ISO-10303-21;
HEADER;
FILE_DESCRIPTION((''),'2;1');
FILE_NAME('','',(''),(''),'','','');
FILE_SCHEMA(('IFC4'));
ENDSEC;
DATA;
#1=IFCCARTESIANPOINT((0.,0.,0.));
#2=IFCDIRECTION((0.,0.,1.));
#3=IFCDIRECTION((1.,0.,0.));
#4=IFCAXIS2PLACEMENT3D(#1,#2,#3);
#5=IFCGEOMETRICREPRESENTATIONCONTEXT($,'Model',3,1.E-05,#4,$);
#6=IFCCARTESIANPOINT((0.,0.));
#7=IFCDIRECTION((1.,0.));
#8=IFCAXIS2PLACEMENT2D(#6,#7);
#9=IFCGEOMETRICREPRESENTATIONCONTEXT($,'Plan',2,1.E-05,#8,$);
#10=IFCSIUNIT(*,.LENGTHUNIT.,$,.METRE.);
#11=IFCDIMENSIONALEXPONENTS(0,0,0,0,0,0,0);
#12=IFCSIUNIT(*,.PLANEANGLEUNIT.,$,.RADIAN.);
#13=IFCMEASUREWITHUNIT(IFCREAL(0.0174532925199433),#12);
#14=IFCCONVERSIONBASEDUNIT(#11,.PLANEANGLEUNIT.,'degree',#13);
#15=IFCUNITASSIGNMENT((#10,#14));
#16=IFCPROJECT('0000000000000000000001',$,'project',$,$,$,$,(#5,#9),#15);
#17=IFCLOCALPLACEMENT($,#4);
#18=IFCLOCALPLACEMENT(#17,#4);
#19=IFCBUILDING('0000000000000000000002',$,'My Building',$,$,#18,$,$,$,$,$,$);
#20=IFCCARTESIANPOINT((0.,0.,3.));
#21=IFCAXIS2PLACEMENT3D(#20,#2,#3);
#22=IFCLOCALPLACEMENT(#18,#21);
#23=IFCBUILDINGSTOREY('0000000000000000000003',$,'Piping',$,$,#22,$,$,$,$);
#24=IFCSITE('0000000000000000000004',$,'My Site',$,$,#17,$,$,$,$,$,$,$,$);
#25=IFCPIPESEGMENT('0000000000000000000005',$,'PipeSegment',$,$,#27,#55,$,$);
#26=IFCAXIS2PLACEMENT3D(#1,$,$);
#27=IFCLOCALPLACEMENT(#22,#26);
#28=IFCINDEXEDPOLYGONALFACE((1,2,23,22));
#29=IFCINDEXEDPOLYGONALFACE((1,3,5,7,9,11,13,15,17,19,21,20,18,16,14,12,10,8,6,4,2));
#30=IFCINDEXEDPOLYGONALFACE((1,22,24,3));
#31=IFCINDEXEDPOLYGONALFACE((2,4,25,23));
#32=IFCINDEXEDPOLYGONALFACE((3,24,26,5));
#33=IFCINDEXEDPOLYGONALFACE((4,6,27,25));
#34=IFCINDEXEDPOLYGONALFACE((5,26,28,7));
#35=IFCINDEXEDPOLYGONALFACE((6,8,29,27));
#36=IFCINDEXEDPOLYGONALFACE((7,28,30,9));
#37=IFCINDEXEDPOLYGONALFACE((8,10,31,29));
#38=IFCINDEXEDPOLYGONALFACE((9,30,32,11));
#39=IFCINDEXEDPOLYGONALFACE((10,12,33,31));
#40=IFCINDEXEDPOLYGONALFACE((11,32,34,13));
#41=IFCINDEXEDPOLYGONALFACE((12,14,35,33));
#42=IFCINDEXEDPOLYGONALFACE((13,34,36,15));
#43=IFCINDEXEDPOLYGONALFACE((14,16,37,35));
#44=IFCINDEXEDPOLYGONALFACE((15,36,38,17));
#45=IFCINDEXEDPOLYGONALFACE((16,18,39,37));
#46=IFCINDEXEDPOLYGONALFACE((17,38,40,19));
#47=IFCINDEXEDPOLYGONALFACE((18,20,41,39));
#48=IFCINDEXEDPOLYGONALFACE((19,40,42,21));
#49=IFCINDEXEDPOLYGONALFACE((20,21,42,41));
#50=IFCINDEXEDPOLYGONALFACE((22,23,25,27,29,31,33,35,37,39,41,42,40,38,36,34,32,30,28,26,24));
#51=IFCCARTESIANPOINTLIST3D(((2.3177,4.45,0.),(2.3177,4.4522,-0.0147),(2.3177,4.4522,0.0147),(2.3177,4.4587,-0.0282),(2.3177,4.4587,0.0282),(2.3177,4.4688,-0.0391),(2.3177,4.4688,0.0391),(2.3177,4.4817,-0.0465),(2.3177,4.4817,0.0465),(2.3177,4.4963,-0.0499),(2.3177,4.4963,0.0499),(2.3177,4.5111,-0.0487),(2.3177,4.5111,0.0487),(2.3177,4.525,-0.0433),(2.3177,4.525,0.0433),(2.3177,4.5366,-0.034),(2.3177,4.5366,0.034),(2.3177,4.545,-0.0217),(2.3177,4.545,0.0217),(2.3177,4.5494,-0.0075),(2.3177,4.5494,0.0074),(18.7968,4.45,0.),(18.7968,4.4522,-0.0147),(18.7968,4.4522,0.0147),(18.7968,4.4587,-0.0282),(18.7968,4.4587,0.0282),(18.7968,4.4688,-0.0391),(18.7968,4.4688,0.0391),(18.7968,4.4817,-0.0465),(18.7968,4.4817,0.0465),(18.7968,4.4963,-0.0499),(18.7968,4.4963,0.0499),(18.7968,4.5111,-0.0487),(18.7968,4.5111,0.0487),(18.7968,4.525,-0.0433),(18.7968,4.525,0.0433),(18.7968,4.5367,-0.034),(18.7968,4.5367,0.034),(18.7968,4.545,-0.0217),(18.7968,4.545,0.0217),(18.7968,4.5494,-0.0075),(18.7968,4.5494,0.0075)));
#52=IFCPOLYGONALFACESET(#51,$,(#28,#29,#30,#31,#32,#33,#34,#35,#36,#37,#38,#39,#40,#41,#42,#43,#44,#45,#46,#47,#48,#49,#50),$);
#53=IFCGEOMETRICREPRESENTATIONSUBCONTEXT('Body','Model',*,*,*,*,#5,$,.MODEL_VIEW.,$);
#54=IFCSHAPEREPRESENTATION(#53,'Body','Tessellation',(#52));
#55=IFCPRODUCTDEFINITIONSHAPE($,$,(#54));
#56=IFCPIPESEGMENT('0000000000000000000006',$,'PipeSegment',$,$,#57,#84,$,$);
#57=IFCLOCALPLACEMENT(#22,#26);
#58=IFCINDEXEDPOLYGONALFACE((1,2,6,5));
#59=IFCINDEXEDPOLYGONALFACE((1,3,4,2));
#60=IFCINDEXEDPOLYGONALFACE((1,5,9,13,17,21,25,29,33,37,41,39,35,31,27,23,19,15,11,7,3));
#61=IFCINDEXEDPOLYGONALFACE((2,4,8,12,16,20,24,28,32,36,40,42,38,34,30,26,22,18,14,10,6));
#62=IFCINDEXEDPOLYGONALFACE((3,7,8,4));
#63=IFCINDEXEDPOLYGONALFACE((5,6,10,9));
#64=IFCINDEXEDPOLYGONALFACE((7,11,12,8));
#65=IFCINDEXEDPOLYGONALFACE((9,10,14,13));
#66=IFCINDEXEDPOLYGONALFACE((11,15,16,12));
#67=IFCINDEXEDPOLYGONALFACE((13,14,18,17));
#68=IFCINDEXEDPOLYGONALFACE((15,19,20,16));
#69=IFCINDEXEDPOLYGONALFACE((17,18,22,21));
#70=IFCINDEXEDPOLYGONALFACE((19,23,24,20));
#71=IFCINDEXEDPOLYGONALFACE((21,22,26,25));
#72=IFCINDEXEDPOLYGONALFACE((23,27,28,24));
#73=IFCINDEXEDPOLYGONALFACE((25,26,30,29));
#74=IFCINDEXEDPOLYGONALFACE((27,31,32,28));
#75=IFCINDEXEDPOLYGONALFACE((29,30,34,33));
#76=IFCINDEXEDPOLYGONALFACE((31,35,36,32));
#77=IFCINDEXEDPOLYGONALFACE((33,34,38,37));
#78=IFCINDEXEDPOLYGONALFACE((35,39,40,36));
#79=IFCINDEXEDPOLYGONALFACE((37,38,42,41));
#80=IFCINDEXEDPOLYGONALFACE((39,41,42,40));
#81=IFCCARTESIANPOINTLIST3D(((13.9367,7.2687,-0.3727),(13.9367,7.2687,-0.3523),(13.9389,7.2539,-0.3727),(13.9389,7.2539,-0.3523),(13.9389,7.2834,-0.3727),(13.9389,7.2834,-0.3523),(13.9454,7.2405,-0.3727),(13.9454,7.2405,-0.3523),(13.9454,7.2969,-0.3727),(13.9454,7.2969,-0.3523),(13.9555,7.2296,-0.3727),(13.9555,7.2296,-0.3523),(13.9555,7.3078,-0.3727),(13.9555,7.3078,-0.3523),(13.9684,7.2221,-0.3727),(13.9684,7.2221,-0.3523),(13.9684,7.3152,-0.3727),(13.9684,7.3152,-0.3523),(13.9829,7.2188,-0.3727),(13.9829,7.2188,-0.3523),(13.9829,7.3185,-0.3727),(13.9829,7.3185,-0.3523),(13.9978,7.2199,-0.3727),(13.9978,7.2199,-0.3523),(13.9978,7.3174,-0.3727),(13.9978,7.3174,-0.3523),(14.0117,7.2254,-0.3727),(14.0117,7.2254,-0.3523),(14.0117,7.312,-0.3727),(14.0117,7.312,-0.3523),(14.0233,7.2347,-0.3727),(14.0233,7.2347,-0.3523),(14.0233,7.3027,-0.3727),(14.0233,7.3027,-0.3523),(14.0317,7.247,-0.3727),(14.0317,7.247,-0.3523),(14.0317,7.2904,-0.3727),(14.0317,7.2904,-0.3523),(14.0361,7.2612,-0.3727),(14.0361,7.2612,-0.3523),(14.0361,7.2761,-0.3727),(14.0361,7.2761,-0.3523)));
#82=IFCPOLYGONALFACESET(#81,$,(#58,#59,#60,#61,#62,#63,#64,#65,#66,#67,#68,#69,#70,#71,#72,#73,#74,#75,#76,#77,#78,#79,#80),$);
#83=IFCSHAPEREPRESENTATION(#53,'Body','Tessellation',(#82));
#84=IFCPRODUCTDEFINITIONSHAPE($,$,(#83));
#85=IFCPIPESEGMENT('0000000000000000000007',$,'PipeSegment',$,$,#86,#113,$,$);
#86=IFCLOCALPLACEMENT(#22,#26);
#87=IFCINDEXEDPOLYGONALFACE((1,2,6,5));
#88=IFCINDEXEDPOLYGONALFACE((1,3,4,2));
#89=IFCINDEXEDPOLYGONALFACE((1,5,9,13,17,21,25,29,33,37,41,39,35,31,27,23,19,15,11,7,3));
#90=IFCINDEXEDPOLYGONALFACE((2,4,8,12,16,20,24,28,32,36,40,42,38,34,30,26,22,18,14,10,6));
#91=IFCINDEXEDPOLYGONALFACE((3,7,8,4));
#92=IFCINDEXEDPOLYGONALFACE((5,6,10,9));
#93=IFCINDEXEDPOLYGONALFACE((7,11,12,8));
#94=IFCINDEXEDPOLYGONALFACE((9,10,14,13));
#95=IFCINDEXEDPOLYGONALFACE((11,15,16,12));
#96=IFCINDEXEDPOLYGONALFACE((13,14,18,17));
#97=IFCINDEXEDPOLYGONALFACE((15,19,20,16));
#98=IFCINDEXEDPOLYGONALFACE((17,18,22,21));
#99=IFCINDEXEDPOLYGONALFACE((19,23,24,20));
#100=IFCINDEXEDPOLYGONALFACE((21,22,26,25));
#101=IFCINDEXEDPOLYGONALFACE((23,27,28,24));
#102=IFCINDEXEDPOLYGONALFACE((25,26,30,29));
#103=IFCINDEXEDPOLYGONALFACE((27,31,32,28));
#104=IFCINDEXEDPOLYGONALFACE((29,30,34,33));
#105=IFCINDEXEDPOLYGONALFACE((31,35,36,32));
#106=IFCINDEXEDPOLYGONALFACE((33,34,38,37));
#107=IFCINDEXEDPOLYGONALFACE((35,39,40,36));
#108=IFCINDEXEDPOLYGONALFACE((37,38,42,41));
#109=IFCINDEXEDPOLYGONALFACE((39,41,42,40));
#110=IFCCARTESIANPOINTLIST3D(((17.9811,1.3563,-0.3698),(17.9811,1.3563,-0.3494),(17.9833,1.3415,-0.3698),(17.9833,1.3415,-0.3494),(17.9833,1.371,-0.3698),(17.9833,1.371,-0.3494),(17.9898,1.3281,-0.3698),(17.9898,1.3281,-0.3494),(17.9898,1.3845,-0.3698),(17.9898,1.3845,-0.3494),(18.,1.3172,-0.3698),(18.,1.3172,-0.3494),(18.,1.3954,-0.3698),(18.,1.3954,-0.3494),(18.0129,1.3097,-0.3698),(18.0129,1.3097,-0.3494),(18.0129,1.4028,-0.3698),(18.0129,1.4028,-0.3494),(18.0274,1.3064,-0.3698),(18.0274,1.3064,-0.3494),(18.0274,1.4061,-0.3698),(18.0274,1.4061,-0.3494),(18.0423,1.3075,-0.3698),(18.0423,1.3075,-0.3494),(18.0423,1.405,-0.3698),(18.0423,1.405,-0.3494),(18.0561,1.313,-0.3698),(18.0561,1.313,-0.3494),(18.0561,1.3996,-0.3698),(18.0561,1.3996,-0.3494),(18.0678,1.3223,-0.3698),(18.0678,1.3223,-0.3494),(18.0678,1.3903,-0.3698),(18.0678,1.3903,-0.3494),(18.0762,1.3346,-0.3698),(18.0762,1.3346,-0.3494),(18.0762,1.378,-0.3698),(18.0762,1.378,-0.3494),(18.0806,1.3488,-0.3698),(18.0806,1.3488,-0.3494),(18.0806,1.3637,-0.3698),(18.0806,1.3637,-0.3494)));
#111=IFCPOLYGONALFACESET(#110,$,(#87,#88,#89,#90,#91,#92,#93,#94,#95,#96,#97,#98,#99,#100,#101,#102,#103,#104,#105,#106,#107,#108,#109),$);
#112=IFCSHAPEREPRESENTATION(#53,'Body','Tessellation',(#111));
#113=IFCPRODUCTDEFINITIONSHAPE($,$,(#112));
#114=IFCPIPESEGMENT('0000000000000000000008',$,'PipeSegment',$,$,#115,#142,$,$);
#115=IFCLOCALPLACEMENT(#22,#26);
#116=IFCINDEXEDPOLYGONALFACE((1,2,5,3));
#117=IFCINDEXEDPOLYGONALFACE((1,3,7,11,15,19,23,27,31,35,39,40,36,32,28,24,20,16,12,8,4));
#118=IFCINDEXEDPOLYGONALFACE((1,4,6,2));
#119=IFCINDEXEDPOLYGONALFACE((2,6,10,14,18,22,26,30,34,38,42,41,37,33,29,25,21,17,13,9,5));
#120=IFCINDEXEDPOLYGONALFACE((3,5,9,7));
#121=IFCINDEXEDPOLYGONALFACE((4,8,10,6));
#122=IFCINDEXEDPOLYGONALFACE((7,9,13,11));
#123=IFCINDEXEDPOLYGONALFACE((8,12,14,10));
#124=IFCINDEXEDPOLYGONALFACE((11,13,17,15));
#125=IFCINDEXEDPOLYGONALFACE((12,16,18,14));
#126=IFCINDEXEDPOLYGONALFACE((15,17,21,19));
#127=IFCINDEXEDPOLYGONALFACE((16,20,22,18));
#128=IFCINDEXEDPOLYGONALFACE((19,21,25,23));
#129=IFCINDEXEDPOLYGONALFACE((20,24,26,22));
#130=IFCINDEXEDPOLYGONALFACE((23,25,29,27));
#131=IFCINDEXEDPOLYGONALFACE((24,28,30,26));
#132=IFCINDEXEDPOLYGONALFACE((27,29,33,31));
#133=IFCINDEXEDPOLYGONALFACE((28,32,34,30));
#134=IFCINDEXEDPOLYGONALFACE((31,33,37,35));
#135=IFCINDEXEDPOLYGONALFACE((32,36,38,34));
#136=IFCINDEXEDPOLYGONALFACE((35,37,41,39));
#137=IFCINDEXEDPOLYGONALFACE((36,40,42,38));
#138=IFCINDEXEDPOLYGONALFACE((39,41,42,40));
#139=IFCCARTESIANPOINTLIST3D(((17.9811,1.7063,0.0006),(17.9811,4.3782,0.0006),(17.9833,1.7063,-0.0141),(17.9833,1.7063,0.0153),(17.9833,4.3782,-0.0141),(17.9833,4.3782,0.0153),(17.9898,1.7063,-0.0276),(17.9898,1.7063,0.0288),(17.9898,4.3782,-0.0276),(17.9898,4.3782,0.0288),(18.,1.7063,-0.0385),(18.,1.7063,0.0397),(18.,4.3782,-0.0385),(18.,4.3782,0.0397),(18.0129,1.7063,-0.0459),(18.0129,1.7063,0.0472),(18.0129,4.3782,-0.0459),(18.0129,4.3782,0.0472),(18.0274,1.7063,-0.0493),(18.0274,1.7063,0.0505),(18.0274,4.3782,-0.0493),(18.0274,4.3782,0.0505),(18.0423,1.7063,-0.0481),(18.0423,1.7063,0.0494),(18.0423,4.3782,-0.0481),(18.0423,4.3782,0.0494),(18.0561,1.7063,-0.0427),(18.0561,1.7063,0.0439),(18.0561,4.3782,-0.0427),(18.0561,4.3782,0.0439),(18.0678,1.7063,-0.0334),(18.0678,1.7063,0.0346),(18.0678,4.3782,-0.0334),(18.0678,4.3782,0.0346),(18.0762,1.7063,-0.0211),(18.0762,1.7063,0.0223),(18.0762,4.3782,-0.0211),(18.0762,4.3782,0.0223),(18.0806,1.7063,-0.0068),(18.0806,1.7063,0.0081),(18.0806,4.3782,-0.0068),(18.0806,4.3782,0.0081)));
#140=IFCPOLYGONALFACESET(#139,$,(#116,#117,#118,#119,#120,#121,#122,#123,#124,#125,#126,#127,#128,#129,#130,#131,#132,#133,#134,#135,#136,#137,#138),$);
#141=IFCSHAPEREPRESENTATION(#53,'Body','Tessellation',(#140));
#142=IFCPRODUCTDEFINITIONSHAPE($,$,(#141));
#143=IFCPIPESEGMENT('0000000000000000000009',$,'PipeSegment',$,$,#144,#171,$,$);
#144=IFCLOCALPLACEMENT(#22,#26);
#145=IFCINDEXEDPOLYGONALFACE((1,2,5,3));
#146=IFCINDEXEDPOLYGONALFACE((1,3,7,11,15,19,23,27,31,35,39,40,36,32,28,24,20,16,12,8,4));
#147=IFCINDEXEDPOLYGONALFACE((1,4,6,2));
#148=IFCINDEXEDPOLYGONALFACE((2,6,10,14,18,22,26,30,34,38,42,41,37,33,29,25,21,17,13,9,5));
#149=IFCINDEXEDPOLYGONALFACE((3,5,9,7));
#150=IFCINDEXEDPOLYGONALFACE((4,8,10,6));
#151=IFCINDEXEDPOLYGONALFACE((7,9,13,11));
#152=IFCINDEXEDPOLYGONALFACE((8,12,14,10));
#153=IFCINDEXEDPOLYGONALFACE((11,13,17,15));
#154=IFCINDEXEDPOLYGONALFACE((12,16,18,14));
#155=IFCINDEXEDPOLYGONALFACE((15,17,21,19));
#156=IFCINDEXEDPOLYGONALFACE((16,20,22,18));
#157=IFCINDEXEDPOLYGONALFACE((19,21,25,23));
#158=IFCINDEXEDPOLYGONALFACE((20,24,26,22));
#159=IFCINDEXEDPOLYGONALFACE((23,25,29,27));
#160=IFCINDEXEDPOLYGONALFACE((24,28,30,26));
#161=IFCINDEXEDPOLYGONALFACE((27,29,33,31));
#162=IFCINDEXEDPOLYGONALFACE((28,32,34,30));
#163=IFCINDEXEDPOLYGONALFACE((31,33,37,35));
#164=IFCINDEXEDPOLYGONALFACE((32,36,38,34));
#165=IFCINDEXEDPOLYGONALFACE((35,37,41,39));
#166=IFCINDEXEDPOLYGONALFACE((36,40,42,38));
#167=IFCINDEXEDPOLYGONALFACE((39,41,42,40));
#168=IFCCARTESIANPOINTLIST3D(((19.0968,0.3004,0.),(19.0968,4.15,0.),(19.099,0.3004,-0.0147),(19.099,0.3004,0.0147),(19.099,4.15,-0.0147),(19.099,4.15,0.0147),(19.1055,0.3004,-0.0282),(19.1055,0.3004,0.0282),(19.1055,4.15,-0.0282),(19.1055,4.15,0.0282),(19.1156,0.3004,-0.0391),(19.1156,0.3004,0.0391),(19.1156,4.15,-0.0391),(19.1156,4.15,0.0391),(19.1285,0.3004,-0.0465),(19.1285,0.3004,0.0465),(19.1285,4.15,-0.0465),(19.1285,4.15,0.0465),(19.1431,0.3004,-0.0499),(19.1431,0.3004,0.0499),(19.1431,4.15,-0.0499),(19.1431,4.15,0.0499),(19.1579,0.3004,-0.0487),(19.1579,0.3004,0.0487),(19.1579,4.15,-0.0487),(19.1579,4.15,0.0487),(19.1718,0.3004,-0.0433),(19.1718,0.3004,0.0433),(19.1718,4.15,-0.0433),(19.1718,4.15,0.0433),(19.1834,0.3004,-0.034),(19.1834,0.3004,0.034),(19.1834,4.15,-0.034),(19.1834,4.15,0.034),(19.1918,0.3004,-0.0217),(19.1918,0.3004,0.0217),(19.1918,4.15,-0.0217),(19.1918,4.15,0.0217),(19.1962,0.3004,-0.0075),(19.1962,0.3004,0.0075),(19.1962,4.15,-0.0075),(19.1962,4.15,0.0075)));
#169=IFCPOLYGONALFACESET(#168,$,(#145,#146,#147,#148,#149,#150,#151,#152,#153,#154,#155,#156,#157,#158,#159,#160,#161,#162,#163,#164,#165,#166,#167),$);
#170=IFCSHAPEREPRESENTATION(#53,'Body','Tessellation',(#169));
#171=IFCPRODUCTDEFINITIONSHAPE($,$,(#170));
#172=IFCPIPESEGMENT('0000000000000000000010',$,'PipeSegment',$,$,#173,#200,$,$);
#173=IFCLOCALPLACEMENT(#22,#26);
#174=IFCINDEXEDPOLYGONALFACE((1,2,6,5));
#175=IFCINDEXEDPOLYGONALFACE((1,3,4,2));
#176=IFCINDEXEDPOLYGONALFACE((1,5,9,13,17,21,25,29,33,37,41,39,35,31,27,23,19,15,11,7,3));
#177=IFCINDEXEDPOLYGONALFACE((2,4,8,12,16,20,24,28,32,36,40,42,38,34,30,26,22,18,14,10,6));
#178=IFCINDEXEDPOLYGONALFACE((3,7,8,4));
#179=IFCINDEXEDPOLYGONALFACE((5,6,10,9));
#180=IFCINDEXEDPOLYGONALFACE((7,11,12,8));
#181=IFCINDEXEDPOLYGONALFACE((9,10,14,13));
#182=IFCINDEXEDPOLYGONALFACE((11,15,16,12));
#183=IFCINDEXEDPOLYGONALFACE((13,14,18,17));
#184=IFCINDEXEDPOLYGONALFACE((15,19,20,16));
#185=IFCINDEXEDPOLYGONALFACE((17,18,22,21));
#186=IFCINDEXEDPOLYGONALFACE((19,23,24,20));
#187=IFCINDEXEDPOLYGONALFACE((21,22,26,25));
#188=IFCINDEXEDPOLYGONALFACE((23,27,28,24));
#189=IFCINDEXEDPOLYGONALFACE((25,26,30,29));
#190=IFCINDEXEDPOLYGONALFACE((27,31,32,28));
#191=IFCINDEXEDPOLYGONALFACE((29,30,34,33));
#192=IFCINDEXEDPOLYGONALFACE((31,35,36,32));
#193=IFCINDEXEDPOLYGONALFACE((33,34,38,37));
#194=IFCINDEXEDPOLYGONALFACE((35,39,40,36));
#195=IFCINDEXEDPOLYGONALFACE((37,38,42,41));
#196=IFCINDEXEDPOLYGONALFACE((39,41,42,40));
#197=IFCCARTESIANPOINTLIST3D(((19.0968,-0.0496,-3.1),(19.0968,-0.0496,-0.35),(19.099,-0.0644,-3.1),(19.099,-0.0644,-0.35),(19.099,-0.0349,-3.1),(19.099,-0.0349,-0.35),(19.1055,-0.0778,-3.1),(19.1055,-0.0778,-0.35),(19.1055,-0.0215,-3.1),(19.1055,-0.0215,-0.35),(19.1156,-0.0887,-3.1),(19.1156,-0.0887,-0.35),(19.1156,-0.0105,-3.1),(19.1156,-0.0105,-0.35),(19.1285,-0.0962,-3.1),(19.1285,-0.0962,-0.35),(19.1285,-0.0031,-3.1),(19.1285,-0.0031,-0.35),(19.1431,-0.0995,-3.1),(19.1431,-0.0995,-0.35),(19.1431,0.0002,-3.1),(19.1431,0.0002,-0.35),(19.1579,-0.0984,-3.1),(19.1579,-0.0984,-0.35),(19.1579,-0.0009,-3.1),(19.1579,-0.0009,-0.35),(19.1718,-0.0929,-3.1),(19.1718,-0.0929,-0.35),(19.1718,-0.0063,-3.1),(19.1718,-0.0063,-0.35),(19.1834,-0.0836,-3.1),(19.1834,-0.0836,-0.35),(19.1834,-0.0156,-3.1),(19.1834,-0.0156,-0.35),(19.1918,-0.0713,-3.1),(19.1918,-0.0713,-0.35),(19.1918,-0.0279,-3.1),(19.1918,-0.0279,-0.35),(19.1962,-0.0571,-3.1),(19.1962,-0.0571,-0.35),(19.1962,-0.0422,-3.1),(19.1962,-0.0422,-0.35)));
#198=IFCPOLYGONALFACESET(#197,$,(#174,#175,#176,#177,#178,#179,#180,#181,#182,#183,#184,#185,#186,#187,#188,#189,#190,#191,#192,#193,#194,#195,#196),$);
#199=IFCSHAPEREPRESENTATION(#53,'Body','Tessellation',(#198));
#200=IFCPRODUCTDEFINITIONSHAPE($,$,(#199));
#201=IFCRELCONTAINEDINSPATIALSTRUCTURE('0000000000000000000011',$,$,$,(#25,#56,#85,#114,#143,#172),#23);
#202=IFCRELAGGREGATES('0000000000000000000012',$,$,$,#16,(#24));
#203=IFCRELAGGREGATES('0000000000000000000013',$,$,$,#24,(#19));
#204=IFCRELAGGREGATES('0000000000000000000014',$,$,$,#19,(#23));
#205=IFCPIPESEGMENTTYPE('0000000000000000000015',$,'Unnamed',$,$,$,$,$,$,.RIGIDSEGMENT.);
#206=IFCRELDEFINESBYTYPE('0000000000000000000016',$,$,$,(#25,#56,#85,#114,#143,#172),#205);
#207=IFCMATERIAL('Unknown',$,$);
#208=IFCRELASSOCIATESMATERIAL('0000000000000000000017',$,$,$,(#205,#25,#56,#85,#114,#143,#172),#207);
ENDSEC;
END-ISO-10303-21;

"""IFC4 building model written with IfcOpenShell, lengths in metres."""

from ifc_helpers import new_model, entity, si_unit, converted_unit, frame, origin_with_axes, origin_2d_with_axis, place, context, subcontext, project, spatial, circle, extrude, material, material_profile, profile_set, profile_usage, type_object, element, save


model = new_model("IFC4")

# Units and contexts
model_context = context("Model", 3, precision=1e-05, world=origin_with_axes())
plan_context = context("Plan", 2, precision=1e-05, world=origin_2d_with_axis())
body_context = subcontext(model_context, "Body", "Model", "MODEL_VIEW")
ifc_project = project(units=[si_unit("LENGTHUNIT", "METRE"), converted_unit("PLANEANGLEUNIT", "degree", entity("IfcReal", 0.0174532925199433), si_unit("PLANEANGLEUNIT", "RADIAN"), dimensions=[0, 0, 0, 0, 0, 0, 0])], contexts=[model_context, plan_context])

# Site, building, storey
site_placement = place(None, origin_with_axes())
site = spatial("IfcSite", under=ifc_project, at=site_placement, Name="My Site")
building_placement = place(site_placement, origin_with_axes())
building = spatial("IfcBuilding", under=site, at=building_placement, Name="My Building")
storey_placement = place(building_placement, frame((0.0, 0.0, 3.0), z_axis=(0.0, 0.0, 1.0), x_axis=(1.0, 0.0, 0.0)))
storey = spatial("IfcBuildingStorey", under=building, at=storey_placement, Name="Piping")

# Pipe segments
ifc_material = material(Name="Unknown")
ifc_material_profile_1 = material_profile(ifc_material, circle(Radius=0.05))
ifc_profile_set_1 = profile_set([ifc_material_profile_1])
ifc_profile_usage_1 = profile_usage(ifc_profile_set_1, cardinal=5)
pipe_segment_type = type_object("IfcPipeSegmentType", Name="Unnamed", PredefinedType="RIGIDSEGMENT", material=ifc_profile_set_1)
pipe_segment_1_placement = place(storey_placement, frame((18.7968, 4.5, 0.0), z_axis=(-1.0, 0.0, 0.0), x_axis=(0.0, -1.0, 0.0)))
element("IfcPipeSegment", 1, at=pipe_segment_1_placement, inside=storey, type_object=pipe_segment_type, material=ifc_profile_usage_1, Name="PipeSegment", context=body_context, shape_type="SweptSolid", body=[
    extrude(circle(Radius=0.05), origin_with_axes(), (0.0, 0.0, 1.0), 16.4791),
])
ifc_profile_usage_2 = profile_usage(ifc_profile_set_1, cardinal=5)
pipe_segment_2_placement = place(storey_placement, frame((13.9867, 7.2687, -0.3523), z_axis=(0.0, 0.0, -1.0), x_axis=(-1.0, 0.0, 0.0)))
element("IfcPipeSegment", 2, at=pipe_segment_2_placement, inside=storey, type_object=pipe_segment_type, material=ifc_profile_usage_2, Name="PipeSegment", context=body_context, shape_type="SweptSolid", body=[
    extrude(circle(Radius=0.05), origin_with_axes(), (0.0, 0.0, 1.0), 0.0204),
])
ifc_profile_usage_3 = profile_usage(ifc_profile_set_1, cardinal=5)
pipe_segment_3_placement = place(storey_placement, frame((18.0311, 1.3563, -0.3494), z_axis=(0.0, 0.0, -1.0), x_axis=(-1.0, 0.0, 0.0)))
element("IfcPipeSegment", 3, at=pipe_segment_3_placement, inside=storey, type_object=pipe_segment_type, material=ifc_profile_usage_3, Name="PipeSegment", context=body_context, shape_type="SweptSolid", body=[
    extrude(circle(Radius=0.05), origin_with_axes(), (0.0, 0.0, 1.0), 0.0204),
])
ifc_profile_usage_4 = profile_usage(ifc_profile_set_1, cardinal=5)
pipe_segment_4_placement = place(storey_placement, frame((18.0311, 1.7063, 0.0006), z_axis=(0.0, 1.0, 0.0), x_axis=(-1.0, 0.0, 0.0)))
element("IfcPipeSegment", 4, at=pipe_segment_4_placement, inside=storey, type_object=pipe_segment_type, material=ifc_profile_usage_4, Name="PipeSegment", context=body_context, shape_type="SweptSolid", body=[
    extrude(circle(Radius=0.05), origin_with_axes(), (0.0, 0.0, 1.0), 2.6719),
])
ifc_profile_usage_5 = profile_usage(ifc_profile_set_1, cardinal=5)
pipe_segment_5_placement = place(storey_placement, frame((19.1468, 0.3004, 0.0), z_axis=(0.0, 1.0, 0.0), x_axis=(-1.0, 0.0, 0.0)))
element("IfcPipeSegment", 5, at=pipe_segment_5_placement, inside=storey, type_object=pipe_segment_type, material=ifc_profile_usage_5, Name="PipeSegment", context=body_context, shape_type="SweptSolid", body=[
    extrude(circle(Radius=0.05), origin_with_axes(), (0.0, 0.0, 1.0), 3.8496),
])
ifc_profile_usage_6 = profile_usage(ifc_profile_set_1, cardinal=5)
pipe_segment_6_placement = place(storey_placement, frame((19.1468, -0.0496, -0.35), z_axis=(0.0, 0.0, -1.0), x_axis=(-1.0, 0.0, 0.0)))
element("IfcPipeSegment", 6, at=pipe_segment_6_placement, inside=storey, type_object=pipe_segment_type, material=ifc_profile_usage_6, Name="PipeSegment", context=body_context, shape_type="SweptSolid", body=[
    extrude(circle(Radius=0.05), origin_with_axes(), (0.0, 0.0, 1.0), 2.75),
])

save(model, "model.ifc")
